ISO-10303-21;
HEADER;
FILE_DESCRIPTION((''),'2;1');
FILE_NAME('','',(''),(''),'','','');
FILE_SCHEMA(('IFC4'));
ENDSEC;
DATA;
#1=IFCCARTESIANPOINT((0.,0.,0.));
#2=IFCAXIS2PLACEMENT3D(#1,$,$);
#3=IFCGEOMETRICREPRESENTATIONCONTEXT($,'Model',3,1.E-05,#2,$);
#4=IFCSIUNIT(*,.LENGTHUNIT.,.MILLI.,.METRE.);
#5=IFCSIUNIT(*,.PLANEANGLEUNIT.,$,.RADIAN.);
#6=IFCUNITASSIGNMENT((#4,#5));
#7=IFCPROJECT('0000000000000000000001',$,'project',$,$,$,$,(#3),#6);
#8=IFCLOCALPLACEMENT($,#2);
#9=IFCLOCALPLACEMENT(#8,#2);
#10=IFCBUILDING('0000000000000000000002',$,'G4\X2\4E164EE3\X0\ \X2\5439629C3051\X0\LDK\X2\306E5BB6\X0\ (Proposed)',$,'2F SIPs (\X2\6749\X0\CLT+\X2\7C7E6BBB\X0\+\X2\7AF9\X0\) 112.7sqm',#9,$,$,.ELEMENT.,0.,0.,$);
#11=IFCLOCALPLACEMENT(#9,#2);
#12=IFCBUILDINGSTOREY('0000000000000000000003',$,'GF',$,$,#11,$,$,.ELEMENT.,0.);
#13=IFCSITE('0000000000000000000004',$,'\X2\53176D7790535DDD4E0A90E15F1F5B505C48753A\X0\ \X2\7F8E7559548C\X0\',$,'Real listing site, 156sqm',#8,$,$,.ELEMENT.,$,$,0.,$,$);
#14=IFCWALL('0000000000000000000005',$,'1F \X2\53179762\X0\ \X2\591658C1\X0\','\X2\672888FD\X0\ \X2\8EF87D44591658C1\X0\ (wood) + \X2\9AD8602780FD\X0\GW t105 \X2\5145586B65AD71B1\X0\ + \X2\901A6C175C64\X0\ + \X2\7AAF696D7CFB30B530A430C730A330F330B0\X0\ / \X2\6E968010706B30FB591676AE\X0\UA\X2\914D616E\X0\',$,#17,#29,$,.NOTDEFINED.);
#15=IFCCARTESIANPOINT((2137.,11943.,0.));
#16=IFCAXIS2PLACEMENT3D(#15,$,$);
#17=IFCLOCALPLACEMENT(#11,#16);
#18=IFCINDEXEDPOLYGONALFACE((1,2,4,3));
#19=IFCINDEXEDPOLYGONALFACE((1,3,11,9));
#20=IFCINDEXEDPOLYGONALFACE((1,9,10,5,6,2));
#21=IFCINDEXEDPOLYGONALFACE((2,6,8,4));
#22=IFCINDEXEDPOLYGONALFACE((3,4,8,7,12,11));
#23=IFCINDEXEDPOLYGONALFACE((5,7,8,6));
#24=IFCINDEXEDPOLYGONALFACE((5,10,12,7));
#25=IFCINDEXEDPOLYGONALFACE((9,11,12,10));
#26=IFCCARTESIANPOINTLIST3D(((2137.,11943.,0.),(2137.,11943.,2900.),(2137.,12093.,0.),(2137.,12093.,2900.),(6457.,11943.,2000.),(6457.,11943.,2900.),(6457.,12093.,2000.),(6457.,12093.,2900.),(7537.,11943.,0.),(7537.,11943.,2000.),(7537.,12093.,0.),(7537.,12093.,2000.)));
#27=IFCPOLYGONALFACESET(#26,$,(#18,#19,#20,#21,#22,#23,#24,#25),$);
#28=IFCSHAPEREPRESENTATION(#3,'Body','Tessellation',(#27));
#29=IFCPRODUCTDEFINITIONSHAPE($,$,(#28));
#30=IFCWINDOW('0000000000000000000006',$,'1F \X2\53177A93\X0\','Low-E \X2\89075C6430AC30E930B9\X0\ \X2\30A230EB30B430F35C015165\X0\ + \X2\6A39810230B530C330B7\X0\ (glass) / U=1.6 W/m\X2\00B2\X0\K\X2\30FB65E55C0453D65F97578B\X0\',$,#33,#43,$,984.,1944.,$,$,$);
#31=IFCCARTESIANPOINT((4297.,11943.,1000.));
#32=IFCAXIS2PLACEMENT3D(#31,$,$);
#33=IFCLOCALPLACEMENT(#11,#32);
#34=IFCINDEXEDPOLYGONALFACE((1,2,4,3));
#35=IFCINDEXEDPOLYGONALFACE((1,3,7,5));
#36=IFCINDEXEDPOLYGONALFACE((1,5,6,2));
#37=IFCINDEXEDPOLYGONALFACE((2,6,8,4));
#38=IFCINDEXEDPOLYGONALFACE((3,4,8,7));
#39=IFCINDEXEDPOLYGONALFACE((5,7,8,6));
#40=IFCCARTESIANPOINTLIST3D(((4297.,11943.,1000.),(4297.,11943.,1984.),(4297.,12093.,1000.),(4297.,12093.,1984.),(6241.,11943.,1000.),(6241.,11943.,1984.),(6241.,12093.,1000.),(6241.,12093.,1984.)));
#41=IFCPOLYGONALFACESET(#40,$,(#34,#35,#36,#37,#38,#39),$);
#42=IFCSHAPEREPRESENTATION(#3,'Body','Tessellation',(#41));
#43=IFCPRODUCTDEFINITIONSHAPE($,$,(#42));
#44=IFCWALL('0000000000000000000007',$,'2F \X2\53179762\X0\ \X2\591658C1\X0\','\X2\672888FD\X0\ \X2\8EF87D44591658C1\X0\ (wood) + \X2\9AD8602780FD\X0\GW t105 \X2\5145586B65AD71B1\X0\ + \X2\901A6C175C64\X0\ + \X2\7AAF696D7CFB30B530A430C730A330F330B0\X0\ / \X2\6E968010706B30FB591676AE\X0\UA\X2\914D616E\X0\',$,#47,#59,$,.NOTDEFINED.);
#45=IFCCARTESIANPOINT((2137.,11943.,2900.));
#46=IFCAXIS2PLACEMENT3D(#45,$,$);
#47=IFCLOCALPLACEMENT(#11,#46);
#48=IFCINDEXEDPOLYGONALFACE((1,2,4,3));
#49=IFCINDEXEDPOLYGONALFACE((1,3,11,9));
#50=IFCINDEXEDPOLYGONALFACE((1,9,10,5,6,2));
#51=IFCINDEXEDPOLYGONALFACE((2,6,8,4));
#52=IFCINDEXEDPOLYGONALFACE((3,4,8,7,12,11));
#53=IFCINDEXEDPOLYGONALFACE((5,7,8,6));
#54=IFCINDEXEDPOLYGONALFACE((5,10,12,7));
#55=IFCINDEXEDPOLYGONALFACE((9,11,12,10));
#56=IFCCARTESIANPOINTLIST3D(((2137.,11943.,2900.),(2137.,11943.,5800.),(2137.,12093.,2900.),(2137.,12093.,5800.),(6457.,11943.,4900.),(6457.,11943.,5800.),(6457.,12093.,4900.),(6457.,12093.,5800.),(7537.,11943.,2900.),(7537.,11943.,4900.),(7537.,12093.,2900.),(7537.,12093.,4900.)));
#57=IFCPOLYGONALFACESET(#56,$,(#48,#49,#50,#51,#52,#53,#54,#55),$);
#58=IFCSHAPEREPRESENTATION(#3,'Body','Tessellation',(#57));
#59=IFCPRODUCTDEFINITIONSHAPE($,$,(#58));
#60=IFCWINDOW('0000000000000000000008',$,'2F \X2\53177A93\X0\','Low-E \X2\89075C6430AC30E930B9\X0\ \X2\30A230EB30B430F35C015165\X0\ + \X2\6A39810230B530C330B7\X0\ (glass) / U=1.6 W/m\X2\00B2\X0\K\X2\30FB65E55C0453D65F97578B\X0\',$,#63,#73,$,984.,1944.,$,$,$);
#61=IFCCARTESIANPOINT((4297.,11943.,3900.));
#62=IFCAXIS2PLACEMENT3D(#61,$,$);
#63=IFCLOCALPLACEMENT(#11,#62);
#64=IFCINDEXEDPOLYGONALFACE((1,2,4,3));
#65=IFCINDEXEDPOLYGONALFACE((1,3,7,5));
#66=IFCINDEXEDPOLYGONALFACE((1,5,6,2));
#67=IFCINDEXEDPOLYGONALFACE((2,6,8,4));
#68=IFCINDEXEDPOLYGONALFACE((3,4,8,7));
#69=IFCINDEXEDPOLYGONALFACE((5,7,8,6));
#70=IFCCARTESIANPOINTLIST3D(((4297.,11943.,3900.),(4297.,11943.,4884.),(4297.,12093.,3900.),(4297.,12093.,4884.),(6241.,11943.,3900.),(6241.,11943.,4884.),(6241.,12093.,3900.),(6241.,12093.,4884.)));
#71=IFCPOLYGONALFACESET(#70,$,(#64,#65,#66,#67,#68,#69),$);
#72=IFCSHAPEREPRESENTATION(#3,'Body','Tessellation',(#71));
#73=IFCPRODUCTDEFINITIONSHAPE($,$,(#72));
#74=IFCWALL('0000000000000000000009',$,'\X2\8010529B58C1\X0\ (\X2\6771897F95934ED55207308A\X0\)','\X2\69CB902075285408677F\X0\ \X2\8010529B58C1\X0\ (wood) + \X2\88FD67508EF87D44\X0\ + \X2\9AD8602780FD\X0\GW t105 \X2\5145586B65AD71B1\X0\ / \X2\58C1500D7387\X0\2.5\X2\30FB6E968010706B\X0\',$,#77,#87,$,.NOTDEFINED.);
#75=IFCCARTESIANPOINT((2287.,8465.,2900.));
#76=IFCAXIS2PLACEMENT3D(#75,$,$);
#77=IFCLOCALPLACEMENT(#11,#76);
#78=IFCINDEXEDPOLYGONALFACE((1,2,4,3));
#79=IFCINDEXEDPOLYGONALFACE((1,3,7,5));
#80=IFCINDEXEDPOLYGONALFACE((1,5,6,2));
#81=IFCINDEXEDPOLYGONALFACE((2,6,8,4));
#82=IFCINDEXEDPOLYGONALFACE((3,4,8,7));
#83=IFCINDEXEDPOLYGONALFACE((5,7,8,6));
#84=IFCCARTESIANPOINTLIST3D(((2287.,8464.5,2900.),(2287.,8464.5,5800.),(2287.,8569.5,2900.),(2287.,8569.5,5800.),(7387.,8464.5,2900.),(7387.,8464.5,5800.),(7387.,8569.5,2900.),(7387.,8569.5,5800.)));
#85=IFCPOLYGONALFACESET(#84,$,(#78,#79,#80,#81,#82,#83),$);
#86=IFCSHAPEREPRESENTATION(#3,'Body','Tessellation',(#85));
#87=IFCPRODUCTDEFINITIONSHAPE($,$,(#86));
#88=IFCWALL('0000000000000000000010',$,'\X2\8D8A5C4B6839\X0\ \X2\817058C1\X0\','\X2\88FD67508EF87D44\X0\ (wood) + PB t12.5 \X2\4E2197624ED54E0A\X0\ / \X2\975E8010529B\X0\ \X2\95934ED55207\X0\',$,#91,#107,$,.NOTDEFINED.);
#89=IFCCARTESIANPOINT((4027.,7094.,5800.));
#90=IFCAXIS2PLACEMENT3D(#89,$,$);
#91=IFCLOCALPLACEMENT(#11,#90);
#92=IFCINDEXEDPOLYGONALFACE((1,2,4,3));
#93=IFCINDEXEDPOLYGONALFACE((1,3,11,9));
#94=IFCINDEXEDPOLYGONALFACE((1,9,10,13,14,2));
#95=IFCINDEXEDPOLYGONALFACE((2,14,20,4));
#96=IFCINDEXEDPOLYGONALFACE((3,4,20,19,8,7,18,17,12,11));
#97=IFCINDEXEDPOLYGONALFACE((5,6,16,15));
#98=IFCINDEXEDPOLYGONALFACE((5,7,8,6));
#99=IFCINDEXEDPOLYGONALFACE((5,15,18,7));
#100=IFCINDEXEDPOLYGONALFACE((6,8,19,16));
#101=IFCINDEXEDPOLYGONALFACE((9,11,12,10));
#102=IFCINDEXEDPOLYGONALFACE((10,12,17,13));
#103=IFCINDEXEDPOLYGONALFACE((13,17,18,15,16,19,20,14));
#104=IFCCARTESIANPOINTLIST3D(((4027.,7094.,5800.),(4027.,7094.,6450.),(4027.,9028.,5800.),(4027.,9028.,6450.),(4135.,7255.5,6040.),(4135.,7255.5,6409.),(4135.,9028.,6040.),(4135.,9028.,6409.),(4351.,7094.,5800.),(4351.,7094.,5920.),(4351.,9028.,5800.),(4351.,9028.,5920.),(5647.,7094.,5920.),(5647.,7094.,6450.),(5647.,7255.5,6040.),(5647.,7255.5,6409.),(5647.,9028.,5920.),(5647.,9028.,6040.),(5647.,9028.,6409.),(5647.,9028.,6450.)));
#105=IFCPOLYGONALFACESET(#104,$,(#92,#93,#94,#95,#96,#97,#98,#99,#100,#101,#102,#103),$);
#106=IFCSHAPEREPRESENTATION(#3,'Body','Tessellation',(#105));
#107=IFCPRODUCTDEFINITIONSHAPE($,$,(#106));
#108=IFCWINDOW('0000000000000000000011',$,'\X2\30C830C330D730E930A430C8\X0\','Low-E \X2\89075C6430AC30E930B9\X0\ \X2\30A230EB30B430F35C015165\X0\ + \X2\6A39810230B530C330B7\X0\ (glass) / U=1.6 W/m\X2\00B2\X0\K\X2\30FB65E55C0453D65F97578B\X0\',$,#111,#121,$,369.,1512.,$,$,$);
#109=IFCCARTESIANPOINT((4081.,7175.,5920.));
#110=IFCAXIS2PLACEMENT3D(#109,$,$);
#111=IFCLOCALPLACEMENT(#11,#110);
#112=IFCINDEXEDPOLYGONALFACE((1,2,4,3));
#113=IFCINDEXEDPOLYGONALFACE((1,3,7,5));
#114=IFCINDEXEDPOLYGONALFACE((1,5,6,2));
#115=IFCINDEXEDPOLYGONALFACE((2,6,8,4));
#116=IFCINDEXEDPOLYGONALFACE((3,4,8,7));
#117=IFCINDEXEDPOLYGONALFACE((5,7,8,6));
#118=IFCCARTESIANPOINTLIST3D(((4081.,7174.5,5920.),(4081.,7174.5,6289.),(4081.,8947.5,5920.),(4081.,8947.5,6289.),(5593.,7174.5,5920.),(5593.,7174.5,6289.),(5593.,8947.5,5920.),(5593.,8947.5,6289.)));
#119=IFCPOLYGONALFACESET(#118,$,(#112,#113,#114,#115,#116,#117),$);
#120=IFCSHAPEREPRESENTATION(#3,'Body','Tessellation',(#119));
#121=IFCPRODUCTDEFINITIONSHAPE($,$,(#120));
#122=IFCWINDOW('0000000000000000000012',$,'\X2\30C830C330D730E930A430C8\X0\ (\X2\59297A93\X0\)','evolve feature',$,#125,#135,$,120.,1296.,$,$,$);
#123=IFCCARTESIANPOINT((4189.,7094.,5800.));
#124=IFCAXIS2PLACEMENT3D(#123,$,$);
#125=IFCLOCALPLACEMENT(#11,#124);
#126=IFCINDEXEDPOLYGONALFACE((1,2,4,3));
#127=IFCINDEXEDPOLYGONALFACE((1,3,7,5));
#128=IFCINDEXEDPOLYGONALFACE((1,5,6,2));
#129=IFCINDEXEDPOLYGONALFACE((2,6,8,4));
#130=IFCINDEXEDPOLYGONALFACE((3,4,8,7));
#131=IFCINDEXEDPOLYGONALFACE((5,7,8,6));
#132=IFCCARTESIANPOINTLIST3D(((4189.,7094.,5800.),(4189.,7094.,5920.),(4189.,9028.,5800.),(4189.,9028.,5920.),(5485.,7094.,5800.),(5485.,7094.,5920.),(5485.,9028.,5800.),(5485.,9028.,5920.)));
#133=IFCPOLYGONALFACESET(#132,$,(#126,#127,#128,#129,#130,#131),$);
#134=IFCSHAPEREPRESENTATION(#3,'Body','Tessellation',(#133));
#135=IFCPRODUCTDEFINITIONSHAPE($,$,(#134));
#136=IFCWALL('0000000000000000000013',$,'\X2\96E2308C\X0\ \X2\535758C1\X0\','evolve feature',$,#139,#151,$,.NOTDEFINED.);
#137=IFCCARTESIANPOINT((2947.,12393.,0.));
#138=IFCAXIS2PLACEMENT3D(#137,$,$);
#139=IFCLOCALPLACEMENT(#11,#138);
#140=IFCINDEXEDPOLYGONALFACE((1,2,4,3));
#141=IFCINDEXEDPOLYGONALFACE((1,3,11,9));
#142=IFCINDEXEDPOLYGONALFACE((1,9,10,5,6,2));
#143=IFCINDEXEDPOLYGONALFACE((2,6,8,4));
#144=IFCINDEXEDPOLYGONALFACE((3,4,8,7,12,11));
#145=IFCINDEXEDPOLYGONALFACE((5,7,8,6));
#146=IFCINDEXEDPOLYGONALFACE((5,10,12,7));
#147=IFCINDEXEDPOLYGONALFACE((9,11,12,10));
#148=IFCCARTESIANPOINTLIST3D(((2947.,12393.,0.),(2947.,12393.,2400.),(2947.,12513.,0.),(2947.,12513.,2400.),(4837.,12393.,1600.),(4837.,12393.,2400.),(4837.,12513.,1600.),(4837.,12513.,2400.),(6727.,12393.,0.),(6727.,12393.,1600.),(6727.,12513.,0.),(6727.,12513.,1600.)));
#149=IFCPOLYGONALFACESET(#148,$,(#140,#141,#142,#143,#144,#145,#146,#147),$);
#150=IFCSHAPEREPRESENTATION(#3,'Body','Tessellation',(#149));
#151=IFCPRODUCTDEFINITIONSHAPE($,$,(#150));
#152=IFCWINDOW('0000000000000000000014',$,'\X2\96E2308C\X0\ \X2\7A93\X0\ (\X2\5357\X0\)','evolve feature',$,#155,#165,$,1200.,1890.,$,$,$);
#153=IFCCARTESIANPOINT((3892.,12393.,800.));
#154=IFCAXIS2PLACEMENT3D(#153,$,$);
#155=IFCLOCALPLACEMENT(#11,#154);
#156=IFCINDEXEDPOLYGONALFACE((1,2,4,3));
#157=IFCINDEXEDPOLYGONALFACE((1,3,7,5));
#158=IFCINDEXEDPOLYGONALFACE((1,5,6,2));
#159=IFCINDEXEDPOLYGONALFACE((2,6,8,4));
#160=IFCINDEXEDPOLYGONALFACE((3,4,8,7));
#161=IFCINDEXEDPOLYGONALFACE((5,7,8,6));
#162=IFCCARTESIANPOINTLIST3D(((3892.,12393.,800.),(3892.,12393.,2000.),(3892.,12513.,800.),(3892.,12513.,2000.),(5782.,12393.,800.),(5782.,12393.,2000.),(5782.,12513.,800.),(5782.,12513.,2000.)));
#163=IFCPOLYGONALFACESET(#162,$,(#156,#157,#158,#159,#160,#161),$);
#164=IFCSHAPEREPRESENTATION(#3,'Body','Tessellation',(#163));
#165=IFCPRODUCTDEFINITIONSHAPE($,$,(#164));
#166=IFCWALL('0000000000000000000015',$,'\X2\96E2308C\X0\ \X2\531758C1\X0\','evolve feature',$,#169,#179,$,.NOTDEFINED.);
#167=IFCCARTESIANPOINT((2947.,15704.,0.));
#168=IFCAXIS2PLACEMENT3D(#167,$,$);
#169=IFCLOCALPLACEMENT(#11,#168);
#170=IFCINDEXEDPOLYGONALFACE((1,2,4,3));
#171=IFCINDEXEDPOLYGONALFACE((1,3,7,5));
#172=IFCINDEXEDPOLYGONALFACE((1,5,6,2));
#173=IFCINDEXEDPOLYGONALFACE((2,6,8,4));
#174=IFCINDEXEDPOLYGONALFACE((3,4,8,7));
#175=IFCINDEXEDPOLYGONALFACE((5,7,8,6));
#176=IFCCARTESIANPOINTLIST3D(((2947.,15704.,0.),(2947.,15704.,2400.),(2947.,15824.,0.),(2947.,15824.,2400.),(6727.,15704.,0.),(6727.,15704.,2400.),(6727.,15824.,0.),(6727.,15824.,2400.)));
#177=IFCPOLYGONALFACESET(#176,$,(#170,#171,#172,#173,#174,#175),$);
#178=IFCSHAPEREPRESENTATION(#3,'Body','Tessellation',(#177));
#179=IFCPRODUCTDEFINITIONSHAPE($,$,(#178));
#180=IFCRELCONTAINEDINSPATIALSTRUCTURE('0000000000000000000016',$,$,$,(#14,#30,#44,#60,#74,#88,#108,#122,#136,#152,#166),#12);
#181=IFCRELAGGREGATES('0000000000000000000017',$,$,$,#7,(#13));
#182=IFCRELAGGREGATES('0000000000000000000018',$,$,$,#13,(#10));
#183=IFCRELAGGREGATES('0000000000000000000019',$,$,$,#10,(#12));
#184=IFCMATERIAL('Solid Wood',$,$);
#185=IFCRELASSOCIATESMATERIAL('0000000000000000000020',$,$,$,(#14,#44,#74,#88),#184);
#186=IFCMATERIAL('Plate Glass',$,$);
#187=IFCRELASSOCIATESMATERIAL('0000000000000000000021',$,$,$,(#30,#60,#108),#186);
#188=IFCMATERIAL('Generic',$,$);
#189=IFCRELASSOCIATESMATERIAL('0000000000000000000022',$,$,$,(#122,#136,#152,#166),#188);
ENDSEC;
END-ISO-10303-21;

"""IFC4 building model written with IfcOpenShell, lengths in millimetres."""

from ifc_helpers import new_model, si_unit, frame, frame_2d, origin, place, context, project, spatial, rectangle, extrude, material, element, fill, save


model = new_model("IFC4")

# Units and contexts
model_context = context("Model", 3, precision=1e-05, world=origin())
ifc_project = project(units=[si_unit("LENGTHUNIT", "METRE", prefix="MILLI"), si_unit("PLANEANGLEUNIT", "RADIAN")], contexts=[model_context])

# Site, building, storey
site_placement = place(None, origin())
site = spatial("IfcSite", under=ifc_project, at=site_placement, Name="北海道川上郡弟子屈町 美留和", ObjectType="Real listing site, 156sqm", CompositionType="ELEMENT", RefElevation=0.0)
building_placement = place(site_placement, origin())
building = spatial("IfcBuilding", under=site, at=building_placement, Name="G4世代 吹抜けLDKの家 (Proposed)", ObjectType="2F SIPs (杉CLT+籾殻+竹) 112.7sqm", CompositionType="ELEMENT", ElevationOfRefHeight=0.0, ElevationOfTerrain=0.0)
storey_placement = place(building_placement, origin())
storey = spatial("IfcBuildingStorey", under=building, at=storey_placement, Name="GF", CompositionType="ELEMENT", Elevation=0.0)

# Shared definitions
ifc_material_1 = material(Name="Generic")

# Wall, opening, window
ifc_material_2 = material(Name="Solid Wood")
wall_1_placement = place(storey_placement, frame((2137.0, 11943.0, 0.0)))
wall_1 = element("IfcWall", 1, at=wall_1_placement, inside=storey, material=ifc_material_2, Name="1F 北面 外壁", Description="木製 軸組外壁 (wood) + 高性能GW t105 充填断熱 + 通気層 + 窯業系サイディング / 準耐火・外皮UA配慮", PredefinedType="NOTDEFINED", context=model_context, shape_type="SweptSolid", body=[
    extrude(rectangle(XDim=5400.0, YDim=150.0, at=frame_2d((2700.0, 75.0))), frame((2137.0, 11943.0, 0.0)), (0.0, 0.0, 1.0), 2900.0),
])
opening_1_placement = place(storey_placement, frame((4297.0, 11943.0, 1000.0)))
opening_1 = element("IfcOpeningElement", 2, at=opening_1_placement, cuts=wall_1, PredefinedType="NOTDEFINED", context=model_context, shape_type="SweptSolid", body=[
    extrude(rectangle(XDim=1944.0, YDim=150.0, at=frame_2d((972.0, 75.0))), frame((4297.0, 11943.0, 1000.0)), (0.0, 0.0, 1.0), 984.0),
])
ifc_material_3 = material(Name="Plate Glass")
window_1_placement = place(storey_placement, frame((4297.0, 11943.0, 1000.0)))
window_1 = element("IfcWindow", 3, at=window_1_placement, inside=storey, material=ifc_material_3, Name="1F 北窓", Description="Low-E 複層ガラス アルゴン封入 + 樹脂サッシ (glass) / U=1.6 W/m²K・日射取得型", OverallHeight=984.0, OverallWidth=1944.0, context=model_context, shape_type="SweptSolid", body=[
    extrude(rectangle(XDim=1944.0, YDim=150.0, at=frame_2d((972.0, 75.0))), frame((4297.0, 11943.0, 1000.0)), (0.0, 0.0, 1.0), 984.0),
])
fill(opening_1, window_1)

# Wall, opening, window
wall_2_placement = place(storey_placement, frame((2137.0, 11943.0, 2900.0)))
wall_2 = element("IfcWall", 4, at=wall_2_placement, inside=storey, material=ifc_material_2, Name="2F 北面 外壁", Description="木製 軸組外壁 (wood) + 高性能GW t105 充填断熱 + 通気層 + 窯業系サイディング / 準耐火・外皮UA配慮", PredefinedType="NOTDEFINED", context=model_context, shape_type="SweptSolid", body=[
    extrude(rectangle(XDim=5400.0, YDim=150.0, at=frame_2d((2700.0, 75.0))), frame((2137.0, 11943.0, 2900.0)), (0.0, 0.0, 1.0), 2900.0),
])
opening_2_placement = place(storey_placement, frame((4297.0, 11943.0, 3900.0)))
opening_2 = element("IfcOpeningElement", 5, at=opening_2_placement, cuts=wall_2, PredefinedType="NOTDEFINED", context=model_context, shape_type="SweptSolid", body=[
    extrude(rectangle(XDim=1944.0, YDim=150.0, at=frame_2d((972.0, 75.0))), frame((4297.0, 11943.0, 3900.0)), (0.0, 0.0, 1.0), 984.0),
])
window_2_placement = place(storey_placement, frame((4297.0, 11943.0, 3900.0)))
window_2 = element("IfcWindow", 6, at=window_2_placement, inside=storey, material=ifc_material_3, Name="2F 北窓", Description="Low-E 複層ガラス アルゴン封入 + 樹脂サッシ (glass) / U=1.6 W/m²K・日射取得型", OverallHeight=984.0, OverallWidth=1944.0, context=model_context, shape_type="SweptSolid", body=[
    extrude(rectangle(XDim=1944.0, YDim=150.0, at=frame_2d((972.0, 75.0))), frame((4297.0, 11943.0, 3900.0)), (0.0, 0.0, 1.0), 984.0),
])
fill(opening_2, window_2)

# Wall
wall_3_placement = place(storey_placement, frame((2287.0, 8465.0, 2900.0)))
element("IfcWall", 7, at=wall_3_placement, inside=storey, material=ifc_material_2, Name="耐力壁 (東西間仕切り)", Description="構造用合板 耐力壁 (wood) + 製材軸組 + 高性能GW t105 充填断熱 / 壁倍率2.5・準耐火", PredefinedType="NOTDEFINED", context=model_context, shape_type="SweptSolid", body=[
    extrude(rectangle(XDim=5100.0, YDim=105.0, at=frame_2d((2550.0, 52.0))), frame((2287.0, 8465.0, 2900.0)), (0.0, 0.0, 1.0), 2900.0),
])

# Wall, openings, windows
wall_4_placement = place(storey_placement, frame((4027.0, 7094.0, 5800.0)))
wall_4 = element("IfcWall", 8, at=wall_4_placement, inside=storey, material=ifc_material_2, Name="越屋根 腰壁", Description="製材軸組 (wood) + PB t12.5 両面仕上 / 非耐力 間仕切", PredefinedType="NOTDEFINED", context=model_context, shape_type="SweptSolid", body=[
    extrude(rectangle(XDim=1620.0, YDim=1934.0, at=frame_2d((810.0, 967.0))), frame((4027.0, 7094.0, 5800.0)), (0.0, 0.0, 1.0), 650.0),
])
opening_3_placement = place(storey_placement, frame((4081.0, 7175.0, 5920.0)))
opening_3 = element("IfcOpeningElement", 9, at=opening_3_placement, cuts=wall_4, PredefinedType="NOTDEFINED", context=model_context, shape_type="SweptSolid", body=[
    extrude(rectangle(XDim=1512.0, YDim=1773.0, at=frame_2d((756.0, 886.0))), frame((4081.0, 7175.0, 5920.0)), (0.0, 0.0, 1.0), 369.0),
])
opening_4_placement = place(storey_placement, frame((4189.0, 7094.0, 5800.0)))
opening_4 = element("IfcOpeningElement", 10, at=opening_4_placement, cuts=wall_4, PredefinedType="NOTDEFINED", context=model_context, shape_type="SweptSolid", body=[
    extrude(rectangle(XDim=1296.0, YDim=1934.0, at=frame_2d((648.0, 967.0))), frame((4189.0, 7094.0, 5800.0)), (0.0, 0.0, 1.0), 120.0),
])
window_3_placement = place(storey_placement, frame((4081.0, 7175.0, 5920.0)))
window_3 = element("IfcWindow", 11, at=window_3_placement, inside=storey, material=ifc_material_3, Name="トップライト", Description="Low-E 複層ガラス アルゴン封入 + 樹脂サッシ (glass) / U=1.6 W/m²K・日射取得型", OverallHeight=369.0, OverallWidth=1512.0, context=model_context, shape_type="SweptSolid", body=[
    extrude(rectangle(XDim=1512.0, YDim=1773.0, at=frame_2d((756.0, 886.0))), frame((4081.0, 7175.0, 5920.0)), (0.0, 0.0, 1.0), 369.0),
])
fill(opening_3, window_3)
window_4_placement = place(storey_placement, frame((4189.0, 7094.0, 5800.0)))
window_4 = element("IfcWindow", 12, at=window_4_placement, inside=storey, material=ifc_material_1, Name="トップライト (天窓)", Description="evolve feature", OverallHeight=120.0, OverallWidth=1296.0, context=model_context, shape_type="SweptSolid", body=[
    extrude(rectangle(XDim=1296.0, YDim=1934.0, at=frame_2d((648.0, 967.0))), frame((4189.0, 7094.0, 5800.0)), (0.0, 0.0, 1.0), 120.0),
])
fill(opening_4, window_4)

# Wall, opening, window
wall_5_placement = place(storey_placement, frame((2947.0, 12393.0, 0.0)))
wall_5 = element("IfcWall", 13, at=wall_5_placement, inside=storey, material=ifc_material_1, Name="離れ 南壁", Description="evolve feature", PredefinedType="NOTDEFINED", context=model_context, shape_type="SweptSolid", body=[
    extrude(rectangle(XDim=3780.0, YDim=120.0, at=frame_2d((1890.0, 60.0))), frame((2947.0, 12393.0, 0.0)), (0.0, 0.0, 1.0), 2400.0),
])
opening_5_placement = place(storey_placement, frame((3892.0, 12393.0, 800.0)))
opening_5 = element("IfcOpeningElement", 14, at=opening_5_placement, cuts=wall_5, PredefinedType="NOTDEFINED", context=model_context, shape_type="SweptSolid", body=[
    extrude(rectangle(XDim=1890.0, YDim=120.0, at=frame_2d((945.0, 60.0))), frame((3892.0, 12393.0, 800.0)), (0.0, 0.0, 1.0), 1200.0),
])
window_5_placement = place(storey_placement, frame((3892.0, 12393.0, 800.0)))
window_5 = element("IfcWindow", 15, at=window_5_placement, inside=storey, material=ifc_material_1, Name="離れ 窓 (南)", Description="evolve feature", OverallHeight=1200.0, OverallWidth=1890.0, context=model_context, shape_type="SweptSolid", body=[
    extrude(rectangle(XDim=1890.0, YDim=120.0, at=frame_2d((945.0, 60.0))), frame((3892.0, 12393.0, 800.0)), (0.0, 0.0, 1.0), 1200.0),
])
fill(opening_5, window_5)

# Wall
wall_6_placement = place(storey_placement, frame((2947.0, 15704.0, 0.0)))
element("IfcWall", 16, at=wall_6_placement, inside=storey, material=ifc_material_1, Name="離れ 北壁", Description="evolve feature", PredefinedType="NOTDEFINED", context=model_context, shape_type="SweptSolid", body=[
    extrude(rectangle(XDim=3780.0, YDim=120.0, at=frame_2d((1890.0, 60.0))), frame((2947.0, 15704.0, 0.0)), (0.0, 0.0, 1.0), 2400.0),
])

save(model, "model.ifc")
